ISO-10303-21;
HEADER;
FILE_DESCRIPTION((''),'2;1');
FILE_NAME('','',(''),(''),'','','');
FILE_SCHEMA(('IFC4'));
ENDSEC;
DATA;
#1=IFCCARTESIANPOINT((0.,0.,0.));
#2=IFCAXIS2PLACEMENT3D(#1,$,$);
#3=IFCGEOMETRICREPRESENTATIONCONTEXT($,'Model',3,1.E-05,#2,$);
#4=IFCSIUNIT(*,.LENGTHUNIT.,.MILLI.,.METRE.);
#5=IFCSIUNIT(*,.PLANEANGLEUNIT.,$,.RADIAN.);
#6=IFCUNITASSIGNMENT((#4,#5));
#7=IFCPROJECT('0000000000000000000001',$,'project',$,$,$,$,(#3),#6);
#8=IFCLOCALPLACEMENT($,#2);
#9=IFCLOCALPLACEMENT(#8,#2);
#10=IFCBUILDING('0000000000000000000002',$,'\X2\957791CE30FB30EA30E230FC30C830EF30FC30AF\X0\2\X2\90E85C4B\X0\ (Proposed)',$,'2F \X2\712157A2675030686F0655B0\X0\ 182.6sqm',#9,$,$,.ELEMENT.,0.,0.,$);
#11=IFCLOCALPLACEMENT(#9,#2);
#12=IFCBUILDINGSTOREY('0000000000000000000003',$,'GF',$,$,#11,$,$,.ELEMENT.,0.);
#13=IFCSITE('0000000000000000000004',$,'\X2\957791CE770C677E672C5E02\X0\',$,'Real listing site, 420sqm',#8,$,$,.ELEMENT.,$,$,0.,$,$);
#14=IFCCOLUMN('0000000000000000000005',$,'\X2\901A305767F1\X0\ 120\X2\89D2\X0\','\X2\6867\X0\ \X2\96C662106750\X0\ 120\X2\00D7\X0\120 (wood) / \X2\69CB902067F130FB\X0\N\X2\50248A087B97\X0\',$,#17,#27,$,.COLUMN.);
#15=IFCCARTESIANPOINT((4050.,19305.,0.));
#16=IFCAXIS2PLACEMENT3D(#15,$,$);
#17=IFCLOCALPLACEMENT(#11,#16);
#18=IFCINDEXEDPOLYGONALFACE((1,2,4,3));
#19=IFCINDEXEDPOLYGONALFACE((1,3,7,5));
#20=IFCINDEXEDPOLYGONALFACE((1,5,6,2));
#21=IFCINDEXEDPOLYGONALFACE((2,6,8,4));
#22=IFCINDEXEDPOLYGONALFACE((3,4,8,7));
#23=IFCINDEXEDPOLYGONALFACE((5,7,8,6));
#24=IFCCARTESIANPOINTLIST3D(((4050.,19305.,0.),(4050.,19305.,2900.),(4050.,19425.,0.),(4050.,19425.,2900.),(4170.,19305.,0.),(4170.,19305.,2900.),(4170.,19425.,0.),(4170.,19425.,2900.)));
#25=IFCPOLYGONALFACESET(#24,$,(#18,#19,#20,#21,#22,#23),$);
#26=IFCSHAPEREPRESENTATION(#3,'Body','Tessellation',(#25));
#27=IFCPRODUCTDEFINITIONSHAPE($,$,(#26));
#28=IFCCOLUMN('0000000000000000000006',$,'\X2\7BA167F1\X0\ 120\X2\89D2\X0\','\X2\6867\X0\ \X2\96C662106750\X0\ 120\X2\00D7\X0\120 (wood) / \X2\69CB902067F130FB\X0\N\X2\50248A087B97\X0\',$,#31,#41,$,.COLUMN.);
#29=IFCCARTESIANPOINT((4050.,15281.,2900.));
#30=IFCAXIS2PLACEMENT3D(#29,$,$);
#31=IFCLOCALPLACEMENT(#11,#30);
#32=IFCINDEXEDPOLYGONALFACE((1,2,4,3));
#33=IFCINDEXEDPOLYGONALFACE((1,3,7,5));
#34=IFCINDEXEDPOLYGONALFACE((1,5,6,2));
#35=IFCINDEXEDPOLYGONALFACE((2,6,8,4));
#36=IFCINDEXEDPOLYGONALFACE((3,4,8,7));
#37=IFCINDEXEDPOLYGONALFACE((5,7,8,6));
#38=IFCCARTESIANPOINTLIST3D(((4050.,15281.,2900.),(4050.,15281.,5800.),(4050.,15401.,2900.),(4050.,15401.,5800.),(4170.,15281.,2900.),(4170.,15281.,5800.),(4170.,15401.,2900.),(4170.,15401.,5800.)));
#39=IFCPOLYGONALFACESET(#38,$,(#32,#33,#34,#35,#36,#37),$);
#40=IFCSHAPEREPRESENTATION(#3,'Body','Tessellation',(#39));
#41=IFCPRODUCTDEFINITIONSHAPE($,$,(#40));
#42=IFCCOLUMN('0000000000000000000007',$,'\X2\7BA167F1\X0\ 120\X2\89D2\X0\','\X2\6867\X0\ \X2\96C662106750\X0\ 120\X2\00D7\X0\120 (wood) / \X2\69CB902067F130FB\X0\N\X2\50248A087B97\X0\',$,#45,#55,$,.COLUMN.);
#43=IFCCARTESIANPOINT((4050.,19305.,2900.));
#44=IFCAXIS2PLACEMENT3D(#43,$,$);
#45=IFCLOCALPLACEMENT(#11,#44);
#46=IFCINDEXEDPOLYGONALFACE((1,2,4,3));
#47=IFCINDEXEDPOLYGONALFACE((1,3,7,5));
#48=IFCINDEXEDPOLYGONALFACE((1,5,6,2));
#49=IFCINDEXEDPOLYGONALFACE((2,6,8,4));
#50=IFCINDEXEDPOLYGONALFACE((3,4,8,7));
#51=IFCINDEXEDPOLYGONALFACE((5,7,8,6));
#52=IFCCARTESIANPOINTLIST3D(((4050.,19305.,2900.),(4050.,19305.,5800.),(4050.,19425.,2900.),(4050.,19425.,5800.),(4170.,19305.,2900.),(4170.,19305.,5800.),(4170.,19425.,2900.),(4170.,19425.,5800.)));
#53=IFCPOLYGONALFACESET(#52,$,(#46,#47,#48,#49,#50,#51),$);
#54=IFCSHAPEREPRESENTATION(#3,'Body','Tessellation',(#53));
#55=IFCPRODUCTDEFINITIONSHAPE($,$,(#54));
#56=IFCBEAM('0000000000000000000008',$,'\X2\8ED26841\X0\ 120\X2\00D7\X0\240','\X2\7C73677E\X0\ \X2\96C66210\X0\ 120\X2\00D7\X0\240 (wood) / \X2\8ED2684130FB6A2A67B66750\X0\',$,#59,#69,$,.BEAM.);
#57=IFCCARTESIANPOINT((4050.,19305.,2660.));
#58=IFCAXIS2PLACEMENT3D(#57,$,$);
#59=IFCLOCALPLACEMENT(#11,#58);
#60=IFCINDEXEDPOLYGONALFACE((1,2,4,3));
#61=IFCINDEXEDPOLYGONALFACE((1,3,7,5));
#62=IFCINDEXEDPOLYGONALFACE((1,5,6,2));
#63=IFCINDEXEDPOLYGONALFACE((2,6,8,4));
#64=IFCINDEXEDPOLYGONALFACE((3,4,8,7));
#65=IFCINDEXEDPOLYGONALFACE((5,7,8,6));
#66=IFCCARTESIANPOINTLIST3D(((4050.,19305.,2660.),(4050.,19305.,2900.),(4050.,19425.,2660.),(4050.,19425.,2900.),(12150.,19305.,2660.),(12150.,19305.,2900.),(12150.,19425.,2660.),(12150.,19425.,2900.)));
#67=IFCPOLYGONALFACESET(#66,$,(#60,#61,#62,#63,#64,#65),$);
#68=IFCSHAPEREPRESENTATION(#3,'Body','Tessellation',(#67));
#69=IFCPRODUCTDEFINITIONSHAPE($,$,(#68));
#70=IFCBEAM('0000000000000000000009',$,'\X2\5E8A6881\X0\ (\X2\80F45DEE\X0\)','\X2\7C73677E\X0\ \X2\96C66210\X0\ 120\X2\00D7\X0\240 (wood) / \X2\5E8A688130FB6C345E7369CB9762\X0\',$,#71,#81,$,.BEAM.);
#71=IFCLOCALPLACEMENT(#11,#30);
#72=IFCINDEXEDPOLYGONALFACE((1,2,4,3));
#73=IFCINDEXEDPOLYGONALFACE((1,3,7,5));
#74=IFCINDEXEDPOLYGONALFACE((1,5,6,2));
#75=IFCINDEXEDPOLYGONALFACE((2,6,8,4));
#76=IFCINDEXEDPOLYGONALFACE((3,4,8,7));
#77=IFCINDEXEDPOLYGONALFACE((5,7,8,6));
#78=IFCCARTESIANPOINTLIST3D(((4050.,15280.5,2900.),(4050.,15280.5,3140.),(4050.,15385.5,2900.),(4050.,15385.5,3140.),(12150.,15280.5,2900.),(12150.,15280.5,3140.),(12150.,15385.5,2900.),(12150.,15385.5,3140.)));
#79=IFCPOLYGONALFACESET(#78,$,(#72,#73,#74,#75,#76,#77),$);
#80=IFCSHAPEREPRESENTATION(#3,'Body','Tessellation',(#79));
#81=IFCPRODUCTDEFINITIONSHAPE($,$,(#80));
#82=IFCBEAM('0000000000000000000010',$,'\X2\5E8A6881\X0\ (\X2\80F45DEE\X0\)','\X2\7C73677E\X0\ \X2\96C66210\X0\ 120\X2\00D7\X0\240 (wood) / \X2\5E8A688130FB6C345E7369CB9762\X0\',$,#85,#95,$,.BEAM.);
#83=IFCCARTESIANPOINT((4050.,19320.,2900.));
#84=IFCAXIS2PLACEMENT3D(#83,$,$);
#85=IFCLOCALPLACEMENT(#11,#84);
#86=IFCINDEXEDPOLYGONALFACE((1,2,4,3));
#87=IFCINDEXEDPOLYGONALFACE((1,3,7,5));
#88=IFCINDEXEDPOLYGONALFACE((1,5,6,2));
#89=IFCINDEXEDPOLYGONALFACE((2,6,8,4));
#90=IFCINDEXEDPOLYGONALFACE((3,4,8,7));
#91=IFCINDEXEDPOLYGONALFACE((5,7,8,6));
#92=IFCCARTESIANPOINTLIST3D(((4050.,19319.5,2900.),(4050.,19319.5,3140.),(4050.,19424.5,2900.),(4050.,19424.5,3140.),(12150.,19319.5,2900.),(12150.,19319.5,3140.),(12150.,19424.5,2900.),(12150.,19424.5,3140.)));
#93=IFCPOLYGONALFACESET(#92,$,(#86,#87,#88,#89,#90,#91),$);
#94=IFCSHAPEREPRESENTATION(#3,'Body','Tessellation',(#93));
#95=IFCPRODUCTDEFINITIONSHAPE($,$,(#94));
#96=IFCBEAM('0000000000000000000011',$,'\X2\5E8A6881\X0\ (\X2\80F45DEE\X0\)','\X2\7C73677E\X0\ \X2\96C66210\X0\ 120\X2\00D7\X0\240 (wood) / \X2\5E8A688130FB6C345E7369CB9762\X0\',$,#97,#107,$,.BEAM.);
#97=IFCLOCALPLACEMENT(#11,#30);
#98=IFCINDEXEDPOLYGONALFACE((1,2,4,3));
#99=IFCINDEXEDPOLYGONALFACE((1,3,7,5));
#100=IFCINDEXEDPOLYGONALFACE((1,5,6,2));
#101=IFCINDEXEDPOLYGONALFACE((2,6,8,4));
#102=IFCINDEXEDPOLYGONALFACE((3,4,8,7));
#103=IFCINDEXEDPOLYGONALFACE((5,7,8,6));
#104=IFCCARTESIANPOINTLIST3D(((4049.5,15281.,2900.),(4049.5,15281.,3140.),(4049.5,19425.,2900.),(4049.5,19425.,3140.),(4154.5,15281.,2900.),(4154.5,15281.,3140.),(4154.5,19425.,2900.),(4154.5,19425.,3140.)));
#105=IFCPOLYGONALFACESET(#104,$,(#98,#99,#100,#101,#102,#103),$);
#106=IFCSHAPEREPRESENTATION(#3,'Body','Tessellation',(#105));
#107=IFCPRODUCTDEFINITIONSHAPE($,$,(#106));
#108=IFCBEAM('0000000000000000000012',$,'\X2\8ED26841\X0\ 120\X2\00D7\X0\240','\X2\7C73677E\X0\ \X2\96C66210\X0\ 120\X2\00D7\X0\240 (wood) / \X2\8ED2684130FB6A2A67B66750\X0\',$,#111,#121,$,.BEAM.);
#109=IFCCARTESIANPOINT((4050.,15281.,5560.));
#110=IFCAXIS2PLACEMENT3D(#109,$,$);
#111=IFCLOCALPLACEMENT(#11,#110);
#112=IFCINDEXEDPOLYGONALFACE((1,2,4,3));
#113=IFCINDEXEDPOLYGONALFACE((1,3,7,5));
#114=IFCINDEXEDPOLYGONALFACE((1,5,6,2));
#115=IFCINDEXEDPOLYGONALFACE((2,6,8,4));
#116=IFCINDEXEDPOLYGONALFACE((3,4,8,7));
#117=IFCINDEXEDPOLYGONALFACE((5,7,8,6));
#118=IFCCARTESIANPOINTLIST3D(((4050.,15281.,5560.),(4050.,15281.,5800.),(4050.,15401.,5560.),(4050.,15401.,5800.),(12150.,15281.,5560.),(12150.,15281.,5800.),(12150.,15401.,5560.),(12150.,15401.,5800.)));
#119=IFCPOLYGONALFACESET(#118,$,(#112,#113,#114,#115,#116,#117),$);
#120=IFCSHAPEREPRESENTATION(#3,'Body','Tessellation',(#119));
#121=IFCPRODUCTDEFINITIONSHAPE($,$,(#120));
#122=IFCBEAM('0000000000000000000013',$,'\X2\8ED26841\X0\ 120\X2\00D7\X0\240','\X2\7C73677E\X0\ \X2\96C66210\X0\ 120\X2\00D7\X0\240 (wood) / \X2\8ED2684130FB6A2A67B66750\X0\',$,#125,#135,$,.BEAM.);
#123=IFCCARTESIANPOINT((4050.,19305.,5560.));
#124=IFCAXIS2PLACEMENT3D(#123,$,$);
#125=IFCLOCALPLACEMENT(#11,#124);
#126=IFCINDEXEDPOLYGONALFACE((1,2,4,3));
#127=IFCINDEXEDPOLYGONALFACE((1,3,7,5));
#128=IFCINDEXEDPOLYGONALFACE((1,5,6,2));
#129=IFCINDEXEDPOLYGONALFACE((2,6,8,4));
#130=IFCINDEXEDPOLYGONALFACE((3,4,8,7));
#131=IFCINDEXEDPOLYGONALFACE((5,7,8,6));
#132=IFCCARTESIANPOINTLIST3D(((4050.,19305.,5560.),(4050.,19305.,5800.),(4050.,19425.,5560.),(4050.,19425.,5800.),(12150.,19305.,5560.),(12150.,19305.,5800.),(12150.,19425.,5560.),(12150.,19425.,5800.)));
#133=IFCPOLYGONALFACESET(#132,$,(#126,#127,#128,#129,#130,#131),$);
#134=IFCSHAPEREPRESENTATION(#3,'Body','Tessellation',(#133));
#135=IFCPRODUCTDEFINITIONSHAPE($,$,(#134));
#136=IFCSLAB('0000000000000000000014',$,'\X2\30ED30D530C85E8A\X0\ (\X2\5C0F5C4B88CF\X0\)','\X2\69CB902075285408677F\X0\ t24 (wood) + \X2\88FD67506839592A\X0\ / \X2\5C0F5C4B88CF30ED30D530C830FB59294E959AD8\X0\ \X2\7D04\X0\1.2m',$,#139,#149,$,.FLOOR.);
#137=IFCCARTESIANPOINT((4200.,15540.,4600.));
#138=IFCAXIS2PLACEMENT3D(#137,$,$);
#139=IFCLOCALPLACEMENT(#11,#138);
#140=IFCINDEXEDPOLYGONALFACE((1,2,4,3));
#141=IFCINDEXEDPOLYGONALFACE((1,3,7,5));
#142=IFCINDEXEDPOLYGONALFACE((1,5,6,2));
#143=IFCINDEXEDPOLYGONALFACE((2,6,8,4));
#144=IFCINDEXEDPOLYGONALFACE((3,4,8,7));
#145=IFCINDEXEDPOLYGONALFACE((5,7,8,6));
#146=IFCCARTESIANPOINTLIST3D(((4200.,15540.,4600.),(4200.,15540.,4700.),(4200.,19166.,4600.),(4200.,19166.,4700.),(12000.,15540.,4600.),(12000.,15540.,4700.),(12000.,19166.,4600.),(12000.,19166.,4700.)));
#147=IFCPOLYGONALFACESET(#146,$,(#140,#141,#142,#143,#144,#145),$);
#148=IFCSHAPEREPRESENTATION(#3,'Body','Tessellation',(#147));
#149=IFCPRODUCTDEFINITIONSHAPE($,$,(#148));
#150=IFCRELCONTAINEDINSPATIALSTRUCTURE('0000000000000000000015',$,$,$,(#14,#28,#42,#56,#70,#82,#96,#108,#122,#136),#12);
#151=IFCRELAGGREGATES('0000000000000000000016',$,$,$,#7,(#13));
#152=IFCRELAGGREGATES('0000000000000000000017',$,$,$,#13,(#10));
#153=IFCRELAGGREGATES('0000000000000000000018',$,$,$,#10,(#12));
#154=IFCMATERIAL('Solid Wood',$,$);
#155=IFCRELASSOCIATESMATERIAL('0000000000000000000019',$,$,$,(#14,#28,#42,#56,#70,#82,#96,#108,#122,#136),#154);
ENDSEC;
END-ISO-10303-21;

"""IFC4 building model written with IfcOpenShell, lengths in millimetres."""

from ifc_helpers import new_model, si_unit, frame, frame_2d, origin, place, context, project, spatial, rectangle, extrude, material, element, save


model = new_model("IFC4")

# Units and contexts
model_context = context("Model", 3, precision=1e-05, world=origin())
ifc_project = project(units=[si_unit("LENGTHUNIT", "METRE", prefix="MILLI"), si_unit("PLANEANGLEUNIT", "RADIAN")], contexts=[model_context])

# Site, building, storey
site_placement = place(None, origin())
site = spatial("IfcSite", under=ifc_project, at=site_placement, Name="長野県松本市", ObjectType="Real listing site, 420sqm", CompositionType="ELEMENT", RefElevation=0.0)
building_placement = place(site_placement, origin())
building = spatial("IfcBuilding", under=site, at=building_placement, Name="長野・リモートワーク2部屋 (Proposed)", ObjectType="2F 無垢材と漆喰 182.6sqm", CompositionType="ELEMENT", ElevationOfRefHeight=0.0, ElevationOfTerrain=0.0)
storey_placement = place(building_placement, origin())
storey = spatial("IfcBuildingStorey", under=building, at=storey_placement, Name="GF", CompositionType="ELEMENT", Elevation=0.0)

# Columns
ifc_material_1 = material(Name="Solid Wood")
column_1_placement = place(storey_placement, frame((4050.0, 19305.0, 0.0)))
element("IfcColumn", 1, at=column_1_placement, inside=storey, material=ifc_material_1, Name="通し柱 120角", Description="桧 集成材 120×120 (wood) / 構造柱・N値計算", PredefinedType="COLUMN", context=model_context, shape_type="SweptSolid", body=[
    extrude(rectangle(XDim=120.0, YDim=120.0, at=frame_2d((60.0, 60.0))), frame((4050.0, 19305.0, 0.0)), (0.0, 0.0, 1.0), 2900.0),
])
column_2_placement = place(storey_placement, frame((4050.0, 15281.0, 2900.0)))
element("IfcColumn", 2, at=column_2_placement, inside=storey, material=ifc_material_1, Name="管柱 120角", Description="桧 集成材 120×120 (wood) / 構造柱・N値計算", PredefinedType="COLUMN", context=model_context, shape_type="SweptSolid", body=[
    extrude(rectangle(XDim=120.0, YDim=120.0, at=frame_2d((60.0, 60.0))), frame((4050.0, 15281.0, 2900.0)), (0.0, 0.0, 1.0), 2900.0),
])
column_3_placement = place(storey_placement, frame((4050.0, 19305.0, 2900.0)))
element("IfcColumn", 3, at=column_3_placement, inside=storey, material=ifc_material_1, Name="管柱 120角", Description="桧 集成材 120×120 (wood) / 構造柱・N値計算", PredefinedType="COLUMN", context=model_context, shape_type="SweptSolid", body=[
    extrude(rectangle(XDim=120.0, YDim=120.0, at=frame_2d((60.0, 60.0))), frame((4050.0, 19305.0, 2900.0)), (0.0, 0.0, 1.0), 2900.0),
])

# Beams
beam_1_placement = place(storey_placement, frame((4050.0, 19305.0, 2660.0)))
element("IfcBeam", 4, at=beam_1_placement, inside=storey, material=ifc_material_1, Name="軒桁 120×240", Description="米松 集成 120×240 (wood) / 軒桁・横架材", PredefinedType="BEAM", context=model_context, shape_type="SweptSolid", body=[
    extrude(rectangle(XDim=8100.0, YDim=120.0, at=frame_2d((4050.0, 60.0))), frame((4050.0, 19305.0, 2660.0)), (0.0, 0.0, 1.0), 240.0),
])
beam_2_placement = place(storey_placement, frame((4050.0, 15281.0, 2900.0)))
element("IfcBeam", 5, at=beam_2_placement, inside=storey, material=ifc_material_1, Name="床梁 (胴差)", Description="米松 集成 120×240 (wood) / 床梁・水平構面", PredefinedType="BEAM", context=model_context, shape_type="SweptSolid", body=[
    extrude(rectangle(XDim=8100.0, YDim=105.0, at=frame_2d((4050.0, 52.0))), frame((4050.0, 15281.0, 2900.0)), (0.0, 0.0, 1.0), 240.0),
])
beam_3_placement = place(storey_placement, frame((4050.0, 19320.0, 2900.0)))
element("IfcBeam", 6, at=beam_3_placement, inside=storey, material=ifc_material_1, Name="床梁 (胴差)", Description="米松 集成 120×240 (wood) / 床梁・水平構面", PredefinedType="BEAM", context=model_context, shape_type="SweptSolid", body=[
    extrude(rectangle(XDim=8100.0, YDim=105.0, at=frame_2d((4050.0, 52.0))), frame((4050.0, 19320.0, 2900.0)), (0.0, 0.0, 1.0), 240.0),
])
beam_4_placement = place(storey_placement, frame((4050.0, 15281.0, 2900.0)))
element("IfcBeam", 7, at=beam_4_placement, inside=storey, material=ifc_material_1, Name="床梁 (胴差)", Description="米松 集成 120×240 (wood) / 床梁・水平構面", PredefinedType="BEAM", context=model_context, shape_type="SweptSolid", body=[
    extrude(rectangle(XDim=105.0, YDim=4144.0, at=frame_2d((52.0, 2072.0))), frame((4050.0, 15281.0, 2900.0)), (0.0, 0.0, 1.0), 240.0),
])
beam_5_placement = place(storey_placement, frame((4050.0, 15281.0, 5560.0)))
element("IfcBeam", 8, at=beam_5_placement, inside=storey, material=ifc_material_1, Name="軒桁 120×240", Description="米松 集成 120×240 (wood) / 軒桁・横架材", PredefinedType="BEAM", context=model_context, shape_type="SweptSolid", body=[
    extrude(rectangle(XDim=8100.0, YDim=120.0, at=frame_2d((4050.0, 60.0))), frame((4050.0, 15281.0, 5560.0)), (0.0, 0.0, 1.0), 240.0),
])
beam_6_placement = place(storey_placement, frame((4050.0, 19305.0, 5560.0)))
element("IfcBeam", 9, at=beam_6_placement, inside=storey, material=ifc_material_1, Name="軒桁 120×240", Description="米松 集成 120×240 (wood) / 軒桁・横架材", PredefinedType="BEAM", context=model_context, shape_type="SweptSolid", body=[
    extrude(rectangle(XDim=8100.0, YDim=120.0, at=frame_2d((4050.0, 60.0))), frame((4050.0, 19305.0, 5560.0)), (0.0, 0.0, 1.0), 240.0),
])

# Slab
slab_placement = place(storey_placement, frame((4200.0, 15540.0, 4600.0)))
element("IfcSlab", 10, at=slab_placement, inside=storey, material=ifc_material_1, Name="ロフト床 (小屋裏)", Description="構造用合板 t24 (wood) + 製材根太 / 小屋裏ロフト・天井高 約1.2m", PredefinedType="FLOOR", context=model_context, shape_type="SweptSolid", body=[
    extrude(rectangle(XDim=7800.0, YDim=3626.0, at=frame_2d((3900.0, 1813.0))), frame((4200.0, 15540.0, 4600.0)), (0.0, 0.0, 1.0), 100.0),
])

save(model, "model.ifc")
